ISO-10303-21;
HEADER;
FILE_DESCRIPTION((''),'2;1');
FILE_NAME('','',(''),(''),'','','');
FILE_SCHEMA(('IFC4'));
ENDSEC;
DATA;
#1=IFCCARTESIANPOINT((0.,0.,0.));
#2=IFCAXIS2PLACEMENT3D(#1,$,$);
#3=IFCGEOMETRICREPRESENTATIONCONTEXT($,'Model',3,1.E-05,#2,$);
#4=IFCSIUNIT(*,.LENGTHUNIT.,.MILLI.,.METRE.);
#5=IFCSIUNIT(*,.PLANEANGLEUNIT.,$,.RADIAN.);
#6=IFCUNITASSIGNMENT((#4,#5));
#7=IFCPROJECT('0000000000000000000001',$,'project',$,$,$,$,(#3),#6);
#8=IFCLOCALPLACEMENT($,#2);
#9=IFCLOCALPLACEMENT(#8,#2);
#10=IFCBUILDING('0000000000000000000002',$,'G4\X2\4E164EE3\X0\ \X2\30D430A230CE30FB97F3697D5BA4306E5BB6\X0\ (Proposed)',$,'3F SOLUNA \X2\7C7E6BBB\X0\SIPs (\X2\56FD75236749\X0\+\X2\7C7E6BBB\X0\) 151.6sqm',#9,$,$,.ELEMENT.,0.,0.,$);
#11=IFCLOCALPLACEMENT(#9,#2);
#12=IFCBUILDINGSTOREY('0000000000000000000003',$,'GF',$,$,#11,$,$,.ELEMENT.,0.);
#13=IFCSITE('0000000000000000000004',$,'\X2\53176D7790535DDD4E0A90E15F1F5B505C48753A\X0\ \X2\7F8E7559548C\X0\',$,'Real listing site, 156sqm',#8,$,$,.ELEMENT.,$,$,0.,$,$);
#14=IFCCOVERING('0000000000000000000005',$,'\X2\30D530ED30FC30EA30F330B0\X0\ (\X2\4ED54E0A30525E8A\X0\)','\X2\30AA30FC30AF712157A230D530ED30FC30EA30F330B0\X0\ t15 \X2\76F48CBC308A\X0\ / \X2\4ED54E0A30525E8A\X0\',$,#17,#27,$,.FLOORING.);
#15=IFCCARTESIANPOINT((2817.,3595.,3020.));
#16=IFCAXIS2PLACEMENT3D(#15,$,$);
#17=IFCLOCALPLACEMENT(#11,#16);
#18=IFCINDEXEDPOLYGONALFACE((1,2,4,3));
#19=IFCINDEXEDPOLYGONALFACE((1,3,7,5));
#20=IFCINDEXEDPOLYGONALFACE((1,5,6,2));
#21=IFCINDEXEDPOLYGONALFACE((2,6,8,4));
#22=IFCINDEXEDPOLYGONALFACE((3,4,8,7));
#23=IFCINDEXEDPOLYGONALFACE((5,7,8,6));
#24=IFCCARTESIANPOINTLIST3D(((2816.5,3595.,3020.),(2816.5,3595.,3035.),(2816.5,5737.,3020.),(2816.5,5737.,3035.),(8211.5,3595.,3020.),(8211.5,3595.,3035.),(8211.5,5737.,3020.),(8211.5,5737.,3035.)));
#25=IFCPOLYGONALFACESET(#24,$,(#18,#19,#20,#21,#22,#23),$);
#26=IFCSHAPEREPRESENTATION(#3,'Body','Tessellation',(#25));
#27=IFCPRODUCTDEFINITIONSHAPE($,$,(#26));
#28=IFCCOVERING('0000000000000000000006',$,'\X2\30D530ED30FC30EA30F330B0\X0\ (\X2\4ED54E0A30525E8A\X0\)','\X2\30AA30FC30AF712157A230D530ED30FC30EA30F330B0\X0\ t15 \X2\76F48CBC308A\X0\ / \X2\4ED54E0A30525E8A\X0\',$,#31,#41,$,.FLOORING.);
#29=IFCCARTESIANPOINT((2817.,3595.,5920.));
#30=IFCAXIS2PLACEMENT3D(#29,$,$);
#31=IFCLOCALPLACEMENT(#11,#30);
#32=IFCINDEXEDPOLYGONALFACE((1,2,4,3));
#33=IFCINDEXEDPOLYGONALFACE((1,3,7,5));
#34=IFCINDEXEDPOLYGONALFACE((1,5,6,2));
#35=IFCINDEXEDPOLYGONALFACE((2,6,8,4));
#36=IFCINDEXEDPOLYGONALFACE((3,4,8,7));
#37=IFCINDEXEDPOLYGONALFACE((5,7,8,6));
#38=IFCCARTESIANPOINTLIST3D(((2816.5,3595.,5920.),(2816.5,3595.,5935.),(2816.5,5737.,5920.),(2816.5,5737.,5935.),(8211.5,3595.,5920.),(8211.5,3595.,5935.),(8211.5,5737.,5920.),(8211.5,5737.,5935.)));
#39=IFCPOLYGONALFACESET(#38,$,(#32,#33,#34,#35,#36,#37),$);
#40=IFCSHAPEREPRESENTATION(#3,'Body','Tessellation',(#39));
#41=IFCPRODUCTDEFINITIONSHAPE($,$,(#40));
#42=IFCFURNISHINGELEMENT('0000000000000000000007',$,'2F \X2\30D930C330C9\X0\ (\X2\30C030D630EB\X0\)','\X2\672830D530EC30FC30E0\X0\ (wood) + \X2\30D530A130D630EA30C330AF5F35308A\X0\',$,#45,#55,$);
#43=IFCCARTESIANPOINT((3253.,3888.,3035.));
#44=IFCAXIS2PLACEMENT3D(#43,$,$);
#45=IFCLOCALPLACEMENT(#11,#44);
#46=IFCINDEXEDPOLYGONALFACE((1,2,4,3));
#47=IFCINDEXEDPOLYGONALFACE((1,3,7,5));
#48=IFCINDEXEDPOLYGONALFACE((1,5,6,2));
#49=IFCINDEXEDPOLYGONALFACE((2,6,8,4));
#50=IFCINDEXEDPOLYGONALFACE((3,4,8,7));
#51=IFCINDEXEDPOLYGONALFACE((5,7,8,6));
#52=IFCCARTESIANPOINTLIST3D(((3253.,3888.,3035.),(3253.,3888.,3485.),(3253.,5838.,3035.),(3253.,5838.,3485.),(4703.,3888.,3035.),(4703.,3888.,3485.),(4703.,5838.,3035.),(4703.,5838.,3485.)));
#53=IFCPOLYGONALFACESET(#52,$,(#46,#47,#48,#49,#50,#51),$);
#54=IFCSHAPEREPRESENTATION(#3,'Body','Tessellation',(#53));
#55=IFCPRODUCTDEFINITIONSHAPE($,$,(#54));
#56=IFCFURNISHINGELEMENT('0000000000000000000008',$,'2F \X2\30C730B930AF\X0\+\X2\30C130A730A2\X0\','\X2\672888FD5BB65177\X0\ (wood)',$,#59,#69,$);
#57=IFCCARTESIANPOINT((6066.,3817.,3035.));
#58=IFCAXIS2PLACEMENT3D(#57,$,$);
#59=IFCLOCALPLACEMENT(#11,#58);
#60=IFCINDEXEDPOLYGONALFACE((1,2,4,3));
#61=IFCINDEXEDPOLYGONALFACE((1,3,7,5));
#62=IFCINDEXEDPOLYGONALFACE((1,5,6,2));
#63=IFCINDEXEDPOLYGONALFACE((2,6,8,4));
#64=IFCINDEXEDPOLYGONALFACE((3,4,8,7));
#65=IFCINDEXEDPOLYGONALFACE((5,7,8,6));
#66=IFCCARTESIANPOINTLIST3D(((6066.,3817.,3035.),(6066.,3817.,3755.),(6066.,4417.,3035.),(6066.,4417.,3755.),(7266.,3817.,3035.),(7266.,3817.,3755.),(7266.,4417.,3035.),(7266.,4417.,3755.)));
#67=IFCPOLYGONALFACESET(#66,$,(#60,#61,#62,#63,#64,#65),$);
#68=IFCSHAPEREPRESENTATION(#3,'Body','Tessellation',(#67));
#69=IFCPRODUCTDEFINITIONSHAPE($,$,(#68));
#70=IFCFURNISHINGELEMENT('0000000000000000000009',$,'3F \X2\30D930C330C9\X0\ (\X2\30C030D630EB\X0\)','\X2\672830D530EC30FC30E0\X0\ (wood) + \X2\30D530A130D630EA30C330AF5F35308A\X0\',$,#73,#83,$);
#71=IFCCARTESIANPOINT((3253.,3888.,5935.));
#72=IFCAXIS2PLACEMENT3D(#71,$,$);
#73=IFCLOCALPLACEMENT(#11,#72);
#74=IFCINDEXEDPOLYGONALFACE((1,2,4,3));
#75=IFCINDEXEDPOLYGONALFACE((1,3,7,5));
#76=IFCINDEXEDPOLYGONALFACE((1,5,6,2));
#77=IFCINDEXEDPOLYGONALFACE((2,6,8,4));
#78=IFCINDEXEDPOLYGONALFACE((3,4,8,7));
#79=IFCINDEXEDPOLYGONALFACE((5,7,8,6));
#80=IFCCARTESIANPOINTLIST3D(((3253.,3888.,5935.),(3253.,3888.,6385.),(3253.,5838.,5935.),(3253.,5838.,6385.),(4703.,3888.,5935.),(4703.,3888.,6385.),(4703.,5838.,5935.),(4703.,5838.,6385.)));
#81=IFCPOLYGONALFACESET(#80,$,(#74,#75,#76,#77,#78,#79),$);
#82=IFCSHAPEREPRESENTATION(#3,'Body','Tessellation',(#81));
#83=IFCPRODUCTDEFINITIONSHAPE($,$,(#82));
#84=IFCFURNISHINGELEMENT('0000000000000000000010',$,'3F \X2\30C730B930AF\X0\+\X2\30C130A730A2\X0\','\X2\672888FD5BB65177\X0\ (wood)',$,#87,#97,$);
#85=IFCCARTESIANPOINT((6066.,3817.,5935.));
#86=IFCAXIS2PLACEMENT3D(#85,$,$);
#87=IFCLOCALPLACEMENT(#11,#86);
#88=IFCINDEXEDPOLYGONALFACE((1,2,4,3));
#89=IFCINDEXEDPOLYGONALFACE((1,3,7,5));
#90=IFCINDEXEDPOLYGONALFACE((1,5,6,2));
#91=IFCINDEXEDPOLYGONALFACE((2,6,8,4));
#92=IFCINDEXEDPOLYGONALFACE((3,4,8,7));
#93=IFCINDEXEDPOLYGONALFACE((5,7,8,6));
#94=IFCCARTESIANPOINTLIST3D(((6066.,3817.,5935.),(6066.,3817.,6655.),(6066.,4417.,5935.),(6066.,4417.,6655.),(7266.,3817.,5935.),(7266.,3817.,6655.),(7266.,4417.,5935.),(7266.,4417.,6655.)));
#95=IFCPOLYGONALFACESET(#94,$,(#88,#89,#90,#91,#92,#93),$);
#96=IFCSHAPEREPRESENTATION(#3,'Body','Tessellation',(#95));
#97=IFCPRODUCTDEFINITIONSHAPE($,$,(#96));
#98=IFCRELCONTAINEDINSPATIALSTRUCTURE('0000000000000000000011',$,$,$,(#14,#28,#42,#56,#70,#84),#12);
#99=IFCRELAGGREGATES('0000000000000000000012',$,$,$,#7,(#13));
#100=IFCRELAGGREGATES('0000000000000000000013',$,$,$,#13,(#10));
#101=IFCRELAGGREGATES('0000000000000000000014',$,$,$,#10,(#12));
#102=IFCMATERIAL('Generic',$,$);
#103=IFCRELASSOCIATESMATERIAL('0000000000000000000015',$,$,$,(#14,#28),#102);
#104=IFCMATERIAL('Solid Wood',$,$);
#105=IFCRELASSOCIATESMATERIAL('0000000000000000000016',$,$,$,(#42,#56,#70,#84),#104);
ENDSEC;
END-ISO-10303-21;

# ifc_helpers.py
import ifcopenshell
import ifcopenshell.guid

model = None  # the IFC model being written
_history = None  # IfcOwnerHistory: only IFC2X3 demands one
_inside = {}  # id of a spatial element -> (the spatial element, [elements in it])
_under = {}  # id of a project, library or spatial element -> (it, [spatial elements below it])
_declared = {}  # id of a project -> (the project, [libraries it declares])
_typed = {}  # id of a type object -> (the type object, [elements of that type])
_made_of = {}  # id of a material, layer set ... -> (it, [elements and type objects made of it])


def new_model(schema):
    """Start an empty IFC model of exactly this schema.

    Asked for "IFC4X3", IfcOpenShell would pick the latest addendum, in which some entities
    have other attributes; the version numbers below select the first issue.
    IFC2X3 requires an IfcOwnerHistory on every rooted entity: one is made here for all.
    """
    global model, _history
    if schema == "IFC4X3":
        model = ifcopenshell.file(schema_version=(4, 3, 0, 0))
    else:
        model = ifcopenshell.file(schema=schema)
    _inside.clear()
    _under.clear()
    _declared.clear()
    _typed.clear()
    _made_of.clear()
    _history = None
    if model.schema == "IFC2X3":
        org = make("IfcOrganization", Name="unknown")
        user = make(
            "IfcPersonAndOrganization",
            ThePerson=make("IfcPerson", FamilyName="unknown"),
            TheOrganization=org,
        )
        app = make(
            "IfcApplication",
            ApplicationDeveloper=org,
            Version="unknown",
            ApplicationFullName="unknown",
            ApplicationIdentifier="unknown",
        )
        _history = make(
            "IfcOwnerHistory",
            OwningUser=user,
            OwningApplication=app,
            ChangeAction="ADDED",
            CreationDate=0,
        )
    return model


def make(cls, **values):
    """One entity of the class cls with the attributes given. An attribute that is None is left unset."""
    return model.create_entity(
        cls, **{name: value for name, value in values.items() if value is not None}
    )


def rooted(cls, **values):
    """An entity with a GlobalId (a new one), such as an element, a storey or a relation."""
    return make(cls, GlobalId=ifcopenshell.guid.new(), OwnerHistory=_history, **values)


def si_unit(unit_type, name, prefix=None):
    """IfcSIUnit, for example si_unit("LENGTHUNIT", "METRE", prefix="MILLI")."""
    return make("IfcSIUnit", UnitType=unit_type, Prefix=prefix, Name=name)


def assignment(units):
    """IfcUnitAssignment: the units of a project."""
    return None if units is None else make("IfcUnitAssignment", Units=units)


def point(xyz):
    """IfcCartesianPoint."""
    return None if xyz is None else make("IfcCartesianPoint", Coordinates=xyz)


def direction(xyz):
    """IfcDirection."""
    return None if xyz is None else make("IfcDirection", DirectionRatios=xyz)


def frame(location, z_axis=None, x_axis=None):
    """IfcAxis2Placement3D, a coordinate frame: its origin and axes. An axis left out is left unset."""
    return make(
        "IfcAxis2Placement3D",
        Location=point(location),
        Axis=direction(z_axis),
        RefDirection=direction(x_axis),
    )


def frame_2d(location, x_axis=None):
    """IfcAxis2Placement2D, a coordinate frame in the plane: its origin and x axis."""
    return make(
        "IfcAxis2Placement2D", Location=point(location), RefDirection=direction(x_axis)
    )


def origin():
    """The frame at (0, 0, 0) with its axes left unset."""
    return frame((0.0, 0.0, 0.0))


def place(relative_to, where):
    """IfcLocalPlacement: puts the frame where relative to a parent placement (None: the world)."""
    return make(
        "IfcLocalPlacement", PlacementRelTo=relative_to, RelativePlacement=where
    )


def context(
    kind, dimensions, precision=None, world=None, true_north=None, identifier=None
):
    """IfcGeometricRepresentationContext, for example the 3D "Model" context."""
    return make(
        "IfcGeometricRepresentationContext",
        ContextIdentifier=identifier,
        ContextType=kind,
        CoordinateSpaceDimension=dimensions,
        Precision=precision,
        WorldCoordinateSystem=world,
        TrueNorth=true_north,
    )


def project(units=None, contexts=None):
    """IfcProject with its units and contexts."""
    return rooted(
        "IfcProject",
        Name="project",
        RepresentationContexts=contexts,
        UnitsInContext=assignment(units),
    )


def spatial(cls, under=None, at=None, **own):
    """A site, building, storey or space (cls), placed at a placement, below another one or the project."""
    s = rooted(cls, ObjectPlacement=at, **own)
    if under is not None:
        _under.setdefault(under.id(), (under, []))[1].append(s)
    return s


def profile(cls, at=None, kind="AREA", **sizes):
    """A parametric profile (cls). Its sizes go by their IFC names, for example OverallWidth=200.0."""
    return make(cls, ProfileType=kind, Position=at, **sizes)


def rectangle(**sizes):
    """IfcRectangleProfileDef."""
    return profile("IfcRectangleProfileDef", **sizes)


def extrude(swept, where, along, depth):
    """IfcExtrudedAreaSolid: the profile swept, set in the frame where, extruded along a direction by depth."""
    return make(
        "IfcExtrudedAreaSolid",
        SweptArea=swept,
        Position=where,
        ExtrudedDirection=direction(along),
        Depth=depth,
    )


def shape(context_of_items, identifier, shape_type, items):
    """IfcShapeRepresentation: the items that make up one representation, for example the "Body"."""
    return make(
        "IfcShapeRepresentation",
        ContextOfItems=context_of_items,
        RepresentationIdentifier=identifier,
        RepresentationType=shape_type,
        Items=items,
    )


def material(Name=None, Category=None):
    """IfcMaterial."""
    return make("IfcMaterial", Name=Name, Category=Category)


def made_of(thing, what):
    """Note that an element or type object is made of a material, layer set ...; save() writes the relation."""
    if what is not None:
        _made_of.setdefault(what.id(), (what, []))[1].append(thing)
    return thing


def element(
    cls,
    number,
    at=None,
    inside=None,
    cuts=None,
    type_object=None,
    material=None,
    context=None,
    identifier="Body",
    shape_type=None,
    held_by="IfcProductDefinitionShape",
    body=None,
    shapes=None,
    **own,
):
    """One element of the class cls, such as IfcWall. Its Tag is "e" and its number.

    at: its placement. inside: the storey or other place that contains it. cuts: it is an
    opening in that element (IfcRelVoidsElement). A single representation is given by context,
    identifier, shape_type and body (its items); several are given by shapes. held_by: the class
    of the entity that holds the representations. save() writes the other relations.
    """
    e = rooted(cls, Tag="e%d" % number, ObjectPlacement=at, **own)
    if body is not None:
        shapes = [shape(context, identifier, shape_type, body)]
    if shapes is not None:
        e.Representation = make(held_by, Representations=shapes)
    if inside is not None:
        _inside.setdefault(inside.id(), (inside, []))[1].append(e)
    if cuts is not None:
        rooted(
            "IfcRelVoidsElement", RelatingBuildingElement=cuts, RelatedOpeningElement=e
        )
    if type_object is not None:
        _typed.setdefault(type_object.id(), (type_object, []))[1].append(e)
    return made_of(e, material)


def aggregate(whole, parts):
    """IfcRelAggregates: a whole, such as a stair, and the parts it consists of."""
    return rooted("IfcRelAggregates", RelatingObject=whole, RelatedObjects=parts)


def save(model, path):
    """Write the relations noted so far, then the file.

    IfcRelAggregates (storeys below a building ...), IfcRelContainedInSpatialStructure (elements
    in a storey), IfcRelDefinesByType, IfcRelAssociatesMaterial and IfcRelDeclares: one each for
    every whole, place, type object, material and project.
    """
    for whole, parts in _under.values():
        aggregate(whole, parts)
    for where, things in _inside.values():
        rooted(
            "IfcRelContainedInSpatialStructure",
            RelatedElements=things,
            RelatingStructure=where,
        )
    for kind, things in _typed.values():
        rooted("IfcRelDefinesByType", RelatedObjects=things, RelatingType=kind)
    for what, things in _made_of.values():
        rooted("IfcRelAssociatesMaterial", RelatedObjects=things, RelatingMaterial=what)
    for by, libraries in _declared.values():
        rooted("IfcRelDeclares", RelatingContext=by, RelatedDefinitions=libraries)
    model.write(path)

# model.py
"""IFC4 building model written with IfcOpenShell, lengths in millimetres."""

from ifc_helpers import new_model, si_unit, frame, frame_2d, origin, place, context, project, spatial, rectangle, extrude, material, element, save


model = new_model("IFC4")

# Units and contexts
model_context = context("Model", 3, precision=1e-05, world=origin())
ifc_project = project(units=[si_unit("LENGTHUNIT", "METRE", prefix="MILLI"), si_unit("PLANEANGLEUNIT", "RADIAN")], contexts=[model_context])

# Site, building, storey
site_placement = place(None, origin())
site = spatial("IfcSite", under=ifc_project, at=site_placement, Name="北海道川上郡弟子屈町 美留和", ObjectType="Real listing site, 156sqm", CompositionType="ELEMENT", RefElevation=0.0)
building_placement = place(site_placement, origin())
building = spatial("IfcBuilding", under=site, at=building_placement, Name="G4世代 ピアノ・音楽室の家 (Proposed)", ObjectType="3F SOLUNA 籾殻SIPs (国産杉+籾殻) 151.6sqm", CompositionType="ELEMENT", ElevationOfRefHeight=0.0, ElevationOfTerrain=0.0)
storey_placement = place(building_placement, origin())
storey = spatial("IfcBuildingStorey", under=building, at=storey_placement, Name="GF", CompositionType="ELEMENT", Elevation=0.0)

# Shared definitions
ifc_material_1 = material(Name="Solid Wood")

# Shared definitions
ifc_material_2 = material(Name="Generic")

# Coverings
covering_1_placement = place(storey_placement, frame((2817.0, 3595.0, 3020.0)))
element("IfcCovering", 1, at=covering_1_placement, inside=storey, material=ifc_material_2, Name="フローリング (仕上げ床)", Description="オーク無垢フローリング t15 直貼り / 仕上げ床", PredefinedType="FLOORING", context=model_context, shape_type="SweptSolid", body=[
    extrude(rectangle(XDim=5395.0, YDim=2142.0, at=frame_2d((2697.0, 1071.0))), frame((2817.0, 3595.0, 3020.0)), (0.0, 0.0, 1.0), 15.0),
])
covering_2_placement = place(storey_placement, frame((2817.0, 3595.0, 5920.0)))
element("IfcCovering", 2, at=covering_2_placement, inside=storey, material=ifc_material_2, Name="フローリング (仕上げ床)", Description="オーク無垢フローリング t15 直貼り / 仕上げ床", PredefinedType="FLOORING", context=model_context, shape_type="SweptSolid", body=[
    extrude(rectangle(XDim=5395.0, YDim=2142.0, at=frame_2d((2697.0, 1071.0))), frame((2817.0, 3595.0, 5920.0)), (0.0, 0.0, 1.0), 15.0),
])

# Furnishing elements
furnishing_1_placement = place(storey_placement, frame((3253.0, 3888.0, 3035.0)))
element("IfcFurnishingElement", 3, at=furnishing_1_placement, inside=storey, material=ifc_material_1, Name="2F ベッド (ダブル)", Description="木フレーム (wood) + ファブリック張り", context=model_context, shape_type="SweptSolid", body=[
    extrude(rectangle(XDim=1450.0, YDim=1950.0, at=frame_2d((725.0, 975.0))), frame((3253.0, 3888.0, 3035.0)), (0.0, 0.0, 1.0), 450.0),
])
furnishing_2_placement = place(storey_placement, frame((6066.0, 3817.0, 3035.0)))
element("IfcFurnishingElement", 4, at=furnishing_2_placement, inside=storey, material=ifc_material_1, Name="2F デスク+チェア", Description="木製家具 (wood)", context=model_context, shape_type="SweptSolid", body=[
    extrude(rectangle(XDim=1200.0, YDim=600.0, at=frame_2d((600.0, 300.0))), frame((6066.0, 3817.0, 3035.0)), (0.0, 0.0, 1.0), 720.0),
])
furnishing_3_placement = place(storey_placement, frame((3253.0, 3888.0, 5935.0)))
element("IfcFurnishingElement", 5, at=furnishing_3_placement, inside=storey, material=ifc_material_1, Name="3F ベッド (ダブル)", Description="木フレーム (wood) + ファブリック張り", context=model_context, shape_type="SweptSolid", body=[
    extrude(rectangle(XDim=1450.0, YDim=1950.0, at=frame_2d((725.0, 975.0))), frame((3253.0, 3888.0, 5935.0)), (0.0, 0.0, 1.0), 450.0),
])
furnishing_4_placement = place(storey_placement, frame((6066.0, 3817.0, 5935.0)))
element("IfcFurnishingElement", 6, at=furnishing_4_placement, inside=storey, material=ifc_material_1, Name="3F デスク+チェア", Description="木製家具 (wood)", context=model_context, shape_type="SweptSolid", body=[
    extrude(rectangle(XDim=1200.0, YDim=600.0, at=frame_2d((600.0, 300.0))), frame((6066.0, 3817.0, 5935.0)), (0.0, 0.0, 1.0), 720.0),
])

save(model, "model.ifc")
